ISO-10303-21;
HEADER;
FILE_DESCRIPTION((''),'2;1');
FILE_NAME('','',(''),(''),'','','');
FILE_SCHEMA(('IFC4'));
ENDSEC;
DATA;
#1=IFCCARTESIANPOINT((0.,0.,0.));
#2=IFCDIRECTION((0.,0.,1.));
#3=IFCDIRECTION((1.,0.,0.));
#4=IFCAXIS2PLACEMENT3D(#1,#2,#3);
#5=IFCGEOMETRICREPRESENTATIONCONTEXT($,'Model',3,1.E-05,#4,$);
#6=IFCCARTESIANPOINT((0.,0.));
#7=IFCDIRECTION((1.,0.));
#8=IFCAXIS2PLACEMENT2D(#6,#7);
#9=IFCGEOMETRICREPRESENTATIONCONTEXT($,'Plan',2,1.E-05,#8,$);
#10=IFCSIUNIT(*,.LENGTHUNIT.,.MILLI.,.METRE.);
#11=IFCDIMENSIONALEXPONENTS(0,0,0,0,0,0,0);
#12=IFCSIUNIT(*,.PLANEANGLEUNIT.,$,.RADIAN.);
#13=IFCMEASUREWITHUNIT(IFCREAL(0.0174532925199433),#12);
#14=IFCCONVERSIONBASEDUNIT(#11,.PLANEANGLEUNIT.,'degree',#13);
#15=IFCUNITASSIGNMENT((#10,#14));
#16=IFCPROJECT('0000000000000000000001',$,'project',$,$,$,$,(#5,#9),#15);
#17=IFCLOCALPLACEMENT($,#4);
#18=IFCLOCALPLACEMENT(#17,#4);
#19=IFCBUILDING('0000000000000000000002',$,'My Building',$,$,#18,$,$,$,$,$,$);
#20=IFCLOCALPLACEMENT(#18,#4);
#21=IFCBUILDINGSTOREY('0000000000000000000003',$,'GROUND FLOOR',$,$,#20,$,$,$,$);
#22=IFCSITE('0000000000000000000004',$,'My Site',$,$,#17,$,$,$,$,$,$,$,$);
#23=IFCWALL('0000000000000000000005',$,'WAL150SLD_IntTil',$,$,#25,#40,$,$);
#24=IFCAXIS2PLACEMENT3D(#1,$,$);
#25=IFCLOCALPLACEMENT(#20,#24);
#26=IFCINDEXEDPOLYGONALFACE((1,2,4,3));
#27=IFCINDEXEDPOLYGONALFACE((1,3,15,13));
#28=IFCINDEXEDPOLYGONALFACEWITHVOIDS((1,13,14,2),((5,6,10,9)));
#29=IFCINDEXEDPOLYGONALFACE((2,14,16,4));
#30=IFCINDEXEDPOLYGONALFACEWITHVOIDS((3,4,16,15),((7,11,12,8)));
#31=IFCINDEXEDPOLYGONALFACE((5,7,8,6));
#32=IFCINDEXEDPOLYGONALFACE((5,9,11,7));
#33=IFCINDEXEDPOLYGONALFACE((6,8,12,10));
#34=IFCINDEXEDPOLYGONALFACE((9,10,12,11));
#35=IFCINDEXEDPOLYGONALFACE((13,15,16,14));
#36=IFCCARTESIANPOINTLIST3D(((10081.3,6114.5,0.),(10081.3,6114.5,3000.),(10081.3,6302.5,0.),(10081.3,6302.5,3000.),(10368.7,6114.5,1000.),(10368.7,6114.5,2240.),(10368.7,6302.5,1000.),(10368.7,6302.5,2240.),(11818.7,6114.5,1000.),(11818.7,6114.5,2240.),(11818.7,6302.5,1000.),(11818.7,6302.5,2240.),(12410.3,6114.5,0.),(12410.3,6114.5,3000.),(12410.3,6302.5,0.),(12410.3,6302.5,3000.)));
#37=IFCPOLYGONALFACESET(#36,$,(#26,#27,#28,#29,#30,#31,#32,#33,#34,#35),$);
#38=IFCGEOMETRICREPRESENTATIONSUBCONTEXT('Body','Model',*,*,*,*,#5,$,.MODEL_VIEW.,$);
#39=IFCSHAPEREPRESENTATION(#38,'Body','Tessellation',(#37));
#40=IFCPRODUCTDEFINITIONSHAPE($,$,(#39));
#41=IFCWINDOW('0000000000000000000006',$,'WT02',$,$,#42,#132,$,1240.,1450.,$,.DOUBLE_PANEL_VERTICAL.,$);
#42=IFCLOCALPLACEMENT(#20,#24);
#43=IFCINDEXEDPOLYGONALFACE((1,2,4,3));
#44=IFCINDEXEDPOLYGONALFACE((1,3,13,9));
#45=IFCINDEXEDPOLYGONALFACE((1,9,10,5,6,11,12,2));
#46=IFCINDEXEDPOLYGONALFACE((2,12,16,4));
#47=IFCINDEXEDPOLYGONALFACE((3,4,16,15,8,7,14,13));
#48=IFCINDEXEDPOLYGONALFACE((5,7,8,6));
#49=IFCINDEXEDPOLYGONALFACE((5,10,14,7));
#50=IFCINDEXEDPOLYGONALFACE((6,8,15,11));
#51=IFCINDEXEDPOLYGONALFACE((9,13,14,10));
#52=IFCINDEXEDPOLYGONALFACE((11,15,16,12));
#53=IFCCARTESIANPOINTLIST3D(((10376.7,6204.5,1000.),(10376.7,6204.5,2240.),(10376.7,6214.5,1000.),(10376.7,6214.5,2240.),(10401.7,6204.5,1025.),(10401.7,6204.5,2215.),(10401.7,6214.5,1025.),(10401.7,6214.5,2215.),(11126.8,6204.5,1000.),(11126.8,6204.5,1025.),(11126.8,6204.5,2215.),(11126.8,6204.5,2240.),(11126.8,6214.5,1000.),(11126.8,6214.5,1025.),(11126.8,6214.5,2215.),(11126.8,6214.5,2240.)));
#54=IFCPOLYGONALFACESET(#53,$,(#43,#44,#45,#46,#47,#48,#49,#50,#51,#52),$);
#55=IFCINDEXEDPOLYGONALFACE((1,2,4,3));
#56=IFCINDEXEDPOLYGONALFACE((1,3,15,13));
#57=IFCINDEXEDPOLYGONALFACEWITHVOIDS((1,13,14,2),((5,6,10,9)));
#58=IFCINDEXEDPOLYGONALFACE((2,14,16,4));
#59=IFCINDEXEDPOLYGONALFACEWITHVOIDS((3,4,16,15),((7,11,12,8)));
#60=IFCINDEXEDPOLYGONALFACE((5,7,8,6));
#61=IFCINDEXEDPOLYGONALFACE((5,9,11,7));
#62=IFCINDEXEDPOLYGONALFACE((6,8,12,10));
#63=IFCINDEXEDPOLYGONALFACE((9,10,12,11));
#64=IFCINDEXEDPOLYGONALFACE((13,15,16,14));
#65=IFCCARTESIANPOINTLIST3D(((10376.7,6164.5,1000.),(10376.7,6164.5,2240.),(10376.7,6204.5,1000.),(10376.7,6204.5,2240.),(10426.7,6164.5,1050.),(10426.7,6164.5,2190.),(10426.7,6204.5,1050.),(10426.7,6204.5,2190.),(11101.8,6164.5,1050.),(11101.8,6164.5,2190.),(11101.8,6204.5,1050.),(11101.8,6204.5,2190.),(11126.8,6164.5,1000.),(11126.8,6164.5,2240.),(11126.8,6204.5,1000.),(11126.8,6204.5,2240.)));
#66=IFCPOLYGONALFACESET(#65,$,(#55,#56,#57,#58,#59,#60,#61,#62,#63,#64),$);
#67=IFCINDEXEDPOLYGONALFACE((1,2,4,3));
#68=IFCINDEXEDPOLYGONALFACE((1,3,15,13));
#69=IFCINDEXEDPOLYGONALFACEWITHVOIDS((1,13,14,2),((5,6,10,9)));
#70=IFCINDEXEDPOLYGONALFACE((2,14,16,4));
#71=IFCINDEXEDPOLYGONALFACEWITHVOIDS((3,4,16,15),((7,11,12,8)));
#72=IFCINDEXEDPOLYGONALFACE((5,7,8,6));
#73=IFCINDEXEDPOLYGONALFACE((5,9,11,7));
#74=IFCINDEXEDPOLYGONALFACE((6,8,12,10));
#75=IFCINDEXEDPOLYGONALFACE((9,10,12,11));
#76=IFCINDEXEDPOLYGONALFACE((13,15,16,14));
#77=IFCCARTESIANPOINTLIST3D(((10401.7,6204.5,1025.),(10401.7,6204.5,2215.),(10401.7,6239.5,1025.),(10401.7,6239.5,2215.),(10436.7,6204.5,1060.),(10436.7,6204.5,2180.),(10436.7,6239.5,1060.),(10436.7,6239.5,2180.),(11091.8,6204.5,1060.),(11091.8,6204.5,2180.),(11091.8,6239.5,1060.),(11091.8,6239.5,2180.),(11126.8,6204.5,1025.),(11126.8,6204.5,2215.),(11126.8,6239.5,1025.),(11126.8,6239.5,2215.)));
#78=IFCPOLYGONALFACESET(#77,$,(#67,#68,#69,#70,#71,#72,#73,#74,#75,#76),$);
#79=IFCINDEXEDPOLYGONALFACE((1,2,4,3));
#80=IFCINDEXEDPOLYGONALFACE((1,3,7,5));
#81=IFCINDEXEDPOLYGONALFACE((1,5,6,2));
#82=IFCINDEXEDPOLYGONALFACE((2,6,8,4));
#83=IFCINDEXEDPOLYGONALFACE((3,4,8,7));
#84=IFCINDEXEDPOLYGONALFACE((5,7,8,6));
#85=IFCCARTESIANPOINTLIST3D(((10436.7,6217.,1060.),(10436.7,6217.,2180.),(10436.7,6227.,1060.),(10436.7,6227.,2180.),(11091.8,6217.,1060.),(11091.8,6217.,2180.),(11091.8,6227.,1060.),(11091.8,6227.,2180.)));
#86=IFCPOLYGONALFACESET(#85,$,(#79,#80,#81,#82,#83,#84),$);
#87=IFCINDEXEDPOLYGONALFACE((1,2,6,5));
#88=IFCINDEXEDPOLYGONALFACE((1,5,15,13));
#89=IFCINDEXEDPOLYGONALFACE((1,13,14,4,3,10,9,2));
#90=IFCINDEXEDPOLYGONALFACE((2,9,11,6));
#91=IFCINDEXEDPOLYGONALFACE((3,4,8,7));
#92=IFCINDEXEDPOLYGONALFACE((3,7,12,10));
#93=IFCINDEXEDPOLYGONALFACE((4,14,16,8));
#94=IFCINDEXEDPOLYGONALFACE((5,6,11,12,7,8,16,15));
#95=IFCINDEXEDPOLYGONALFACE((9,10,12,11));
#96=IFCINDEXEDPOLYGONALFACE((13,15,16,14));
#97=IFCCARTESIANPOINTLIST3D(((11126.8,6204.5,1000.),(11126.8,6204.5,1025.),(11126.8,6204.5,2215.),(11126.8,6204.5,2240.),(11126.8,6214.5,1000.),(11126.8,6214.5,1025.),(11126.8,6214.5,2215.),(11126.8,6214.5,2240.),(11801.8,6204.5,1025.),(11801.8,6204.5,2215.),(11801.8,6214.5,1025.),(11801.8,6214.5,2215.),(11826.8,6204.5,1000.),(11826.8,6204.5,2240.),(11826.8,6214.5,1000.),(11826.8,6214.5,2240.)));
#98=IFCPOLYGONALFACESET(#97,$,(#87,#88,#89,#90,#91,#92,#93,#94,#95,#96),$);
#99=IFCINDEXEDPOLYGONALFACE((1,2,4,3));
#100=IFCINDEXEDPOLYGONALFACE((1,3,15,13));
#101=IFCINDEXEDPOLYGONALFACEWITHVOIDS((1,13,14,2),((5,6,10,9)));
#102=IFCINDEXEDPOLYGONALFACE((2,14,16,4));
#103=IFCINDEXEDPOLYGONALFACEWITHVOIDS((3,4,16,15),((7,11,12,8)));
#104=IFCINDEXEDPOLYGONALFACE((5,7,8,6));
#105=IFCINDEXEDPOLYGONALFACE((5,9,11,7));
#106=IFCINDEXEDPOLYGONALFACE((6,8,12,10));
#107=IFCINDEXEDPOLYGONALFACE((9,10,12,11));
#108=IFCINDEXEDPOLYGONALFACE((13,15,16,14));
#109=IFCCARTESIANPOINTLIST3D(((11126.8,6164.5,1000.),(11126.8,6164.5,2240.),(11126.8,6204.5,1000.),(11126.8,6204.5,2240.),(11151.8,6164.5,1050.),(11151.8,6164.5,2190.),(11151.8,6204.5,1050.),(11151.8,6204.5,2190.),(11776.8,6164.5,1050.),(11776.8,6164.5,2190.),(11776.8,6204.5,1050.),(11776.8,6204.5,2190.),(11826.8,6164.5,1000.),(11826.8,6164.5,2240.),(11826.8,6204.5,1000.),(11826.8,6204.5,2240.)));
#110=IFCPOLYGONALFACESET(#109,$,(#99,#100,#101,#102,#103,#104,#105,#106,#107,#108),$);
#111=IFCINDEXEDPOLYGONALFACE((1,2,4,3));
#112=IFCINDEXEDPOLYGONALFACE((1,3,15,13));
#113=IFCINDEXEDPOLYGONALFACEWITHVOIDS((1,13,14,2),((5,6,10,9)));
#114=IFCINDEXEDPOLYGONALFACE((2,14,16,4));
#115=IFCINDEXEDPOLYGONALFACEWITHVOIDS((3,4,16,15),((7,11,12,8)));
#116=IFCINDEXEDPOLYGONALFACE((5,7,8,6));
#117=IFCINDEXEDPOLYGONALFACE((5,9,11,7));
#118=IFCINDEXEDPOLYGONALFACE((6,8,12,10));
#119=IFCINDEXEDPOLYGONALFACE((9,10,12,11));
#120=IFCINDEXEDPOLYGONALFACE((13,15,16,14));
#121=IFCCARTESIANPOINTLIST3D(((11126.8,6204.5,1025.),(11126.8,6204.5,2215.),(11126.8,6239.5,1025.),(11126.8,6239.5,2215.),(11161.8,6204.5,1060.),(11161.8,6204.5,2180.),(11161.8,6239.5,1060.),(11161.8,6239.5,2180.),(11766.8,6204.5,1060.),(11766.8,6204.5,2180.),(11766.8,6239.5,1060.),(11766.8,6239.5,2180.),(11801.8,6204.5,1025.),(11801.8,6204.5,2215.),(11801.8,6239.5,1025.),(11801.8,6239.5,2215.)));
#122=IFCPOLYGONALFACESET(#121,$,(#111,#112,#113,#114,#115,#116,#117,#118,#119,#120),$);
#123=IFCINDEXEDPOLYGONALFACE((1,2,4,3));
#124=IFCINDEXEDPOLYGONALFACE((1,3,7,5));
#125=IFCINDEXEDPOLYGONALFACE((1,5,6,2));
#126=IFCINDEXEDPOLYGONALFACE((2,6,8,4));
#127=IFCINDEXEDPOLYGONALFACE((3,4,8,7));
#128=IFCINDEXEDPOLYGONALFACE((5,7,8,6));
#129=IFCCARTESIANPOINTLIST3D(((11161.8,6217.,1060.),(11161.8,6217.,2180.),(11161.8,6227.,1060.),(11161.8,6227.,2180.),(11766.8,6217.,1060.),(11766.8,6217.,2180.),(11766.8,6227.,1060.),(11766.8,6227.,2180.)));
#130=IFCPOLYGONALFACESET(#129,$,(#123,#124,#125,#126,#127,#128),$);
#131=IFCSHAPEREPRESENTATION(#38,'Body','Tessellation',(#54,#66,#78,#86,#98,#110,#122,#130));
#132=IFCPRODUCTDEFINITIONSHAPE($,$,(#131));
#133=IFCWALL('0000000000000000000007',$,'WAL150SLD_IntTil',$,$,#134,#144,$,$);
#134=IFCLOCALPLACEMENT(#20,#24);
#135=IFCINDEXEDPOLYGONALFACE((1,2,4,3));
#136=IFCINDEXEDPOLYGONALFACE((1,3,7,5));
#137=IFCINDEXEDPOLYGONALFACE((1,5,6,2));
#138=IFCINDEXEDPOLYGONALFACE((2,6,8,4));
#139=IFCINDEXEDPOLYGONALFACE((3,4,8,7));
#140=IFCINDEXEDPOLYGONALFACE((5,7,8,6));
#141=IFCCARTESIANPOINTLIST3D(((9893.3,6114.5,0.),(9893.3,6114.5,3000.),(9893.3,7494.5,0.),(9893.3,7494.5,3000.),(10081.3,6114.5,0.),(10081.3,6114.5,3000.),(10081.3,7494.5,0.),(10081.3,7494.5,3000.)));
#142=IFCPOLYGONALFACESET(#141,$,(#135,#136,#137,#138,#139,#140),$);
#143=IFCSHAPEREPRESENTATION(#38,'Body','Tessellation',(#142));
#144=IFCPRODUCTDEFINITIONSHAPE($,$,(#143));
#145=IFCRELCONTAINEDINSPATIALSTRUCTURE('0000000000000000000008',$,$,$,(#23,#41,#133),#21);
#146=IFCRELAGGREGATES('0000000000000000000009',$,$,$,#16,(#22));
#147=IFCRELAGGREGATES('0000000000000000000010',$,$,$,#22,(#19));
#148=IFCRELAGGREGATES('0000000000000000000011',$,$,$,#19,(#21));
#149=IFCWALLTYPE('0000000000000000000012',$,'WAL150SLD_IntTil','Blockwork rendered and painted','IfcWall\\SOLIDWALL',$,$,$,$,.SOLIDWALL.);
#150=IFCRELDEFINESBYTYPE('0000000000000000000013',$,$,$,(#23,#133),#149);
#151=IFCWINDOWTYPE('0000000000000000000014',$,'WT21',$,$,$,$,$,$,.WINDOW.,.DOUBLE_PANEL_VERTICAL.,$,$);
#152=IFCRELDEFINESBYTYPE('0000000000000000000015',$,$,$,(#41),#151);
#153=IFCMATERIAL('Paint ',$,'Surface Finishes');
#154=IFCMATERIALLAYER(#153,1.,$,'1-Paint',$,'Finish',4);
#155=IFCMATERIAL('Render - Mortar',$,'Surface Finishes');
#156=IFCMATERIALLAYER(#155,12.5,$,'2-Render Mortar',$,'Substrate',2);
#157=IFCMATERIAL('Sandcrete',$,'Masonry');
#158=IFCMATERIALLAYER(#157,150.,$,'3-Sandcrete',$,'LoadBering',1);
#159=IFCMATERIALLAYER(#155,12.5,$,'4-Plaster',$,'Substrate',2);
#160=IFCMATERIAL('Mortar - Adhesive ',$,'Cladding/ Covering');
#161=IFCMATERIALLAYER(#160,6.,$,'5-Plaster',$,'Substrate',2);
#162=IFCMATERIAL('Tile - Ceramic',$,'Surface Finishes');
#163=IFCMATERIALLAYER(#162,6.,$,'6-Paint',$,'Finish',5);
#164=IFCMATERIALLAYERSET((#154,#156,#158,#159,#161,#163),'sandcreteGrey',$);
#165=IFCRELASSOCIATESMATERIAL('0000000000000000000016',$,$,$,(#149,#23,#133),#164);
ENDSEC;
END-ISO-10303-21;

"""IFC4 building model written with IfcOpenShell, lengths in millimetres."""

from ifc_helpers import new_model, entity, si_unit, converted_unit, frame, origin_with_axes, origin_2d_with_axis, place, context, subcontext, project, spatial, line, indexed_curve, outline, extrude, shape, source, transform, mapped, material, layer, layer_set, layer_usage, type_object, type_shapes, element, fill, save


model = new_model("IFC4")

# Units and contexts
model_context = context("Model", 3, precision=1e-05, world=origin_with_axes())
plan_context = context("Plan", 2, precision=1e-05, world=origin_2d_with_axis())
body_context_1 = subcontext(model_context, "Body", "Model", "MODEL_VIEW")
body_context_2 = subcontext(plan_context, "Body", "Plan", "PLAN_VIEW")
ifc_project = project(units=[si_unit("LENGTHUNIT", "METRE", prefix="MILLI"), converted_unit("PLANEANGLEUNIT", "degree", entity("IfcReal", 0.0174532925199433), si_unit("PLANEANGLEUNIT", "RADIAN"), dimensions=[0, 0, 0, 0, 0, 0, 0])], contexts=[model_context, plan_context])

# Site, building, storey
site_placement = place(None, origin_with_axes())
site = spatial("IfcSite", under=ifc_project, at=site_placement, Name="My Site")
building_placement = place(site_placement, origin_with_axes())
building = spatial("IfcBuilding", under=site, at=building_placement, Name="My Building")
storey_placement = place(building_placement, origin_with_axes())
storey = spatial("IfcBuildingStorey", under=building, at=storey_placement, Name="GROUND FLOOR")

# Shared definitions
shared_shape_1 = source(origin_with_axes(), body_context_1, "Body", "SweptSolid", [
    extrude(outline(indexed_curve([(0.0, 0.0), (1450.0, 0.0), (1450.0, 1240.0), (0.0, 1240.0)], segments=[line(1, 2, 3, 4, 1)])), frame((0.0, -100.0, 0.0), z_axis=(0.0, -1.0, 0.0), x_axis=(1.0, 0.0, 0.0)), (0.0, 0.0, -1.0), 388.0),
])
window_type_1 = type_object("IfcWindowType", Name="WT21", PartitioningType="DOUBLE_PANEL_VERTICAL", PredefinedType="WINDOW")
shared_shape_2 = source(origin_with_axes(), body_context_1, "Body", "SweptSolid", [
    extrude(outline(indexed_curve([(750.0, 0.0), (0.0, 0.0), (0.0, 1240.0), (750.0, 1240.0), (750.0, 1215.0), (25.0, 1215.0), (25.0, 25.0), (750.0, 25.0)], segments=[line(1, 2, 3, 4, 5, 6, 7, 8, 1)])), frame((0.0, 90.0, 0.0), z_axis=(0.0, -1.0, 0.0), x_axis=(1.0, 0.0, 0.0)), (0.0, 0.0, -1.0), 10.0),
    extrude(outline(indexed_curve([(0.0, 0.0), (750.0, 0.0), (750.0, 1240.0), (0.0, 1240.0)], segments=[line(1, 2, 3, 4, 1)]), holes=[indexed_curve([(50.0, 50.0), (725.0, 50.0), (725.0, 1190.0), (50.0, 1190.0)], segments=[line(1, 2, 3, 4, 1)])]), frame((0.0, 50.0, 0.0), z_axis=(0.0, -1.0, 0.0), x_axis=(1.0, 0.0, 0.0)), (0.0, 0.0, -1.0), 40.0),
    extrude(outline(indexed_curve([(0.0, 0.0), (725.0, 0.0), (725.0, 1190.0), (0.0, 1190.0)], segments=[line(1, 2, 3, 4, 1)]), holes=[indexed_curve([(35.0, 35.0), (690.0, 35.0), (690.0, 1155.0), (35.0, 1155.0)], segments=[line(1, 2, 3, 4, 1)])]), frame((25.0, 90.0, 25.0), z_axis=(0.0, -1.0, 0.0), x_axis=(1.0, 0.0, 0.0)), (0.0, 0.0, -1.0), 35.0),
    extrude(outline(indexed_curve([(35.0, 35.0), (690.0, 35.0), (690.0, 1155.0), (35.0, 1155.0)], segments=[line(1, 2, 3, 4, 1)])), frame((25.0, 102.5, 25.0), z_axis=(0.0, -1.0, 0.0), x_axis=(1.0, 0.0, 0.0)), (0.0, 0.0, -1.0), 10.0),
    extrude(outline(indexed_curve([(0.0, 1240.0), (700.0, 1240.0), (700.0, 0.0), (0.0, 0.0), (0.0, 25.0), (675.0, 25.0), (675.0, 1215.0), (0.0, 1215.0)], segments=[line(1, 2, 3, 4, 5, 6, 7, 8, 1)])), frame((750.0, 90.0, 0.0), z_axis=(0.0, -1.0, 0.0), x_axis=(1.0, 0.0, 0.0)), (0.0, 0.0, -1.0), 10.0),
    extrude(outline(indexed_curve([(0.0, 0.0), (700.0, 0.0), (700.0, 1240.0), (0.0, 1240.0)], segments=[line(1, 2, 3, 4, 1)]), holes=[indexed_curve([(25.0, 50.0), (650.0, 50.0), (650.0, 1190.0), (25.0, 1190.0)], segments=[line(1, 2, 3, 4, 1)])]), frame((750.0, 50.0, 0.0), z_axis=(0.0, -1.0, 0.0), x_axis=(1.0, 0.0, 0.0)), (0.0, 0.0, -1.0), 40.0),
    extrude(outline(indexed_curve([(0.0, 0.0), (675.0, 0.0), (675.0, 1190.0), (0.0, 1190.0)], segments=[line(1, 2, 3, 4, 1)]), holes=[indexed_curve([(35.0, 35.0), (640.0, 35.0), (640.0, 1155.0), (35.0, 1155.0)], segments=[line(1, 2, 3, 4, 1)])]), frame((750.0, 90.0, 25.0), z_axis=(0.0, -1.0, 0.0), x_axis=(1.0, 0.0, 0.0)), (0.0, 0.0, -1.0), 35.0),
    extrude(outline(indexed_curve([(35.0, 35.0), (640.0, 35.0), (640.0, 1155.0), (35.0, 1155.0)], segments=[line(1, 2, 3, 4, 1)])), frame((750.0, 102.5, 25.0), z_axis=(0.0, -1.0, 0.0), x_axis=(1.0, 0.0, 0.0)), (0.0, 0.0, -1.0), 10.0),
])
shared_shape_3 = source(origin_with_axes(), body_context_2, "Body", "Curve2D", [
    entity("IfcIndexedPolyCurve", entity("IfcCartesianPointList2D", [[50.0, 50.0], [725.0, 50.0]])),
    entity("IfcIndexedPolyCurve", entity("IfcCartesianPointList2D", [[0.0, 100.0], [25.0, 100.0], [25.0, 90.0], [50.0, 90.0], [50.0, 50.0], [0.0, 50.0]]), [entity("IfcLineIndex", [1, 2, 3, 4, 5, 6, 1])]),
    entity("IfcIndexedPolyCurve", entity("IfcCartesianPointList2D", [[750.0, 100.0], [750.0, 100.0], [750.0, 90.0], [725.0, 90.0], [725.0, 50.0], [750.0, 50.0]])),
    entity("IfcIndexedPolyCurve", entity("IfcCartesianPointList2D", [[25.0, 90.0], [60.0, 90.0], [60.0, 125.0], [25.0, 125.0]]), [entity("IfcLineIndex", [1, 2, 3, 4, 1])]),
    entity("IfcIndexedPolyCurve", entity("IfcCartesianPointList2D", [[750.0, 90.0], [715.0, 90.0], [715.0, 125.0], [750.0, 125.0]]), [entity("IfcLineIndex", [1, 2, 3, 4, 1])]),
    entity("IfcIndexedPolyCurve", entity("IfcCartesianPointList2D", [[60.0, 90.0], [715.0, 90.0]])),
    entity("IfcIndexedPolyCurve", entity("IfcCartesianPointList2D", [[60.0, 125.0], [715.0, 125.0]])),
    entity("IfcIndexedPolyCurve", entity("IfcCartesianPointList2D", [[60.0, 107.5], [715.0, 107.5]])),
    entity("IfcIndexedPolyCurve", entity("IfcCartesianPointList2D", [[775.0, 50.0], [1400.0, 50.0]])),
    entity("IfcIndexedPolyCurve", entity("IfcCartesianPointList2D", [[750.0, 100.0], [750.0, 100.0], [750.0, 90.0], [775.0, 90.0], [775.0, 50.0], [750.0, 50.0]])),
    entity("IfcIndexedPolyCurve", entity("IfcCartesianPointList2D", [[1450.0, 100.0], [1425.0, 100.0], [1425.0, 90.0], [1400.0, 90.0], [1400.0, 50.0], [1450.0, 50.0]]), [entity("IfcLineIndex", [1, 2, 3, 4, 5, 6, 1])]),
    entity("IfcIndexedPolyCurve", entity("IfcCartesianPointList2D", [[750.0, 90.0], [785.0, 90.0], [785.0, 125.0], [750.0, 125.0]]), [entity("IfcLineIndex", [1, 2, 3, 4, 1])]),
    entity("IfcIndexedPolyCurve", entity("IfcCartesianPointList2D", [[1425.0, 90.0], [1390.0, 90.0], [1390.0, 125.0], [1425.0, 125.0]]), [entity("IfcLineIndex", [1, 2, 3, 4, 1])]),
    entity("IfcIndexedPolyCurve", entity("IfcCartesianPointList2D", [[785.0, 90.0], [1390.0, 90.0]])),
    entity("IfcIndexedPolyCurve", entity("IfcCartesianPointList2D", [[785.0, 125.0], [1390.0, 125.0]])),
    entity("IfcIndexedPolyCurve", entity("IfcCartesianPointList2D", [[785.0, 107.5], [1390.0, 107.5]])),
])
type_shapes(window_type_1, [shared_shape_2, shared_shape_3])

# Shared definitions
ifc_material_1 = material(Name="Tile - Ceramic", Category="Surface Finishes")
ifc_material_2 = material(Name="Mortar - Adhesive ", Category="Cladding/ Covering")
ifc_material_3 = material(Name="Render - Mortar", Category="Surface Finishes")
ifc_material_4 = material(Name="Sandcrete", Category="Masonry")

# Wall, opening, window
ifc_material_5 = material(Name="Paint ", Category="Surface Finishes")
ifc_layer_1 = layer(ifc_material_5, 1.0, Name="1-Paint", Category="Finish", Priority=4)
ifc_layer_2 = layer(ifc_material_3, 12.5, Name="2-Render Mortar", Category="Substrate", Priority=2)
ifc_layer_3 = layer(ifc_material_4, 150.0, Name="3-Sandcrete", Category="LoadBering", Priority=1)
ifc_layer_4 = layer(ifc_material_3, 12.5, Name="4-Plaster", Category="Substrate", Priority=2)
ifc_layer_5 = layer(ifc_material_2, 6.0, Name="5-Plaster", Category="Substrate", Priority=2)
ifc_layer_6 = layer(ifc_material_1, 6.0, Name="6-Paint", Category="Finish", Priority=5)
ifc_layer_set_1 = layer_set([ifc_layer_1, ifc_layer_2, ifc_layer_3, ifc_layer_4, ifc_layer_5, ifc_layer_6], Name="sandcreteGrey")
ifc_layer_usage_1 = layer_usage(ifc_layer_set_1, "AXIS2", "POSITIVE", 0.0)
wall_type_1 = type_object("IfcWallType", Name="WAL150SLD_IntTil", Description="Blockwork rendered and painted", ApplicableOccurrence="IfcWall\\SOLIDWALL", PredefinedType="SOLIDWALL", material=ifc_layer_set_1)
wall_1_placement = place(storey_placement, frame((10081.3, 6114.5, 0.0), z_axis=(0.0, 0.0, 1.0), x_axis=(1.0, 0.0, 0.0)))
wall_1 = element("IfcWall", 1, at=wall_1_placement, inside=storey, type_object=wall_type_1, material=ifc_layer_usage_1, Name="WAL150SLD_IntTil", context=body_context_1, shape_type="SweptSolid", body=[
    extrude(outline(indexed_curve([(0.0, 0.0), (0.0, 188.0), (2329.0, 188.0), (2329.0, 0.0), (0.0, 0.0)], self_intersect=False)), origin_with_axes(), (0.0, 0.0, 1.0), 3000.0),
])
opening_1_placement = place(wall_1_placement, frame((287.5, 0.0, 1000.0), z_axis=(0.0, 0.0, 1.0), x_axis=(1.0, 0.0, 0.0)))
opening_1 = element("IfcOpeningElement", 2, at=opening_1_placement, cuts=wall_1, PredefinedType="OPENING", context=body_context_1, shape_type="MappedRepresentation", body=[
    mapped(shared_shape_1, transform((0.0, 0.0, 0.0), x_axis=(1.0, 0.0, 0.0), y_axis=(0.0, 1.0, 0.0), z_axis=(0.0, 0.0, 1.0), scale=1.0)),
])
window_1_placement = place(opening_1_placement, frame((8.0, 0.0, 0.0), z_axis=(0.0, 0.0, 1.0), x_axis=(1.0, 0.0, 0.0)))
window_1 = element("IfcWindow", 3, at=window_1_placement, inside=storey, type_object=window_type_1, Name="WT02", OverallHeight=1240.0, OverallWidth=1450.0, PartitioningType="DOUBLE_PANEL_VERTICAL", shapes=[
    shape(body_context_1, "Body", "MappedRepresentation", [mapped(shared_shape_2, transform((0.0, 0.0, 0.0), x_axis=(1.0, 0.0, 0.0), y_axis=(0.0, 1.0, 0.0), z_axis=(0.0, 0.0, 1.0), scale=1.0))]),
    shape(body_context_2, "Body", "MappedRepresentation", [mapped(shared_shape_3, transform((0.0, 0.0, 0.0), x_axis=(1.0, 0.0, 0.0), y_axis=(0.0, 1.0, 0.0), z_axis=(0.0, 0.0, 1.0), scale=1.0))]),
])
fill(opening_1, window_1)

# Wall
ifc_layer_usage_2 = layer_usage(ifc_layer_set_1, "AXIS2", "POSITIVE", 0.0)
wall_2_placement = place(storey_placement, frame((9893.3, 7494.5, 0.0), z_axis=(0.0, 0.0, 1.0), x_axis=(-0.000001, -1.0, 0.0)))
element("IfcWall", 4, at=wall_2_placement, inside=storey, type_object=wall_type_1, material=ifc_layer_usage_2, Name="WAL150SLD_IntTil", context=body_context_1, shape_type="SweptSolid", body=[
    extrude(outline(indexed_curve([(0.0, 0.0), (0.0, 188.0), (1380.0, 188.0), (1380.0, 0.0), (0.0, 0.0)], self_intersect=False)), origin_with_axes(), (0.0, 0.0, 1.0), 3000.0),
])

save(model, "model.ifc")
